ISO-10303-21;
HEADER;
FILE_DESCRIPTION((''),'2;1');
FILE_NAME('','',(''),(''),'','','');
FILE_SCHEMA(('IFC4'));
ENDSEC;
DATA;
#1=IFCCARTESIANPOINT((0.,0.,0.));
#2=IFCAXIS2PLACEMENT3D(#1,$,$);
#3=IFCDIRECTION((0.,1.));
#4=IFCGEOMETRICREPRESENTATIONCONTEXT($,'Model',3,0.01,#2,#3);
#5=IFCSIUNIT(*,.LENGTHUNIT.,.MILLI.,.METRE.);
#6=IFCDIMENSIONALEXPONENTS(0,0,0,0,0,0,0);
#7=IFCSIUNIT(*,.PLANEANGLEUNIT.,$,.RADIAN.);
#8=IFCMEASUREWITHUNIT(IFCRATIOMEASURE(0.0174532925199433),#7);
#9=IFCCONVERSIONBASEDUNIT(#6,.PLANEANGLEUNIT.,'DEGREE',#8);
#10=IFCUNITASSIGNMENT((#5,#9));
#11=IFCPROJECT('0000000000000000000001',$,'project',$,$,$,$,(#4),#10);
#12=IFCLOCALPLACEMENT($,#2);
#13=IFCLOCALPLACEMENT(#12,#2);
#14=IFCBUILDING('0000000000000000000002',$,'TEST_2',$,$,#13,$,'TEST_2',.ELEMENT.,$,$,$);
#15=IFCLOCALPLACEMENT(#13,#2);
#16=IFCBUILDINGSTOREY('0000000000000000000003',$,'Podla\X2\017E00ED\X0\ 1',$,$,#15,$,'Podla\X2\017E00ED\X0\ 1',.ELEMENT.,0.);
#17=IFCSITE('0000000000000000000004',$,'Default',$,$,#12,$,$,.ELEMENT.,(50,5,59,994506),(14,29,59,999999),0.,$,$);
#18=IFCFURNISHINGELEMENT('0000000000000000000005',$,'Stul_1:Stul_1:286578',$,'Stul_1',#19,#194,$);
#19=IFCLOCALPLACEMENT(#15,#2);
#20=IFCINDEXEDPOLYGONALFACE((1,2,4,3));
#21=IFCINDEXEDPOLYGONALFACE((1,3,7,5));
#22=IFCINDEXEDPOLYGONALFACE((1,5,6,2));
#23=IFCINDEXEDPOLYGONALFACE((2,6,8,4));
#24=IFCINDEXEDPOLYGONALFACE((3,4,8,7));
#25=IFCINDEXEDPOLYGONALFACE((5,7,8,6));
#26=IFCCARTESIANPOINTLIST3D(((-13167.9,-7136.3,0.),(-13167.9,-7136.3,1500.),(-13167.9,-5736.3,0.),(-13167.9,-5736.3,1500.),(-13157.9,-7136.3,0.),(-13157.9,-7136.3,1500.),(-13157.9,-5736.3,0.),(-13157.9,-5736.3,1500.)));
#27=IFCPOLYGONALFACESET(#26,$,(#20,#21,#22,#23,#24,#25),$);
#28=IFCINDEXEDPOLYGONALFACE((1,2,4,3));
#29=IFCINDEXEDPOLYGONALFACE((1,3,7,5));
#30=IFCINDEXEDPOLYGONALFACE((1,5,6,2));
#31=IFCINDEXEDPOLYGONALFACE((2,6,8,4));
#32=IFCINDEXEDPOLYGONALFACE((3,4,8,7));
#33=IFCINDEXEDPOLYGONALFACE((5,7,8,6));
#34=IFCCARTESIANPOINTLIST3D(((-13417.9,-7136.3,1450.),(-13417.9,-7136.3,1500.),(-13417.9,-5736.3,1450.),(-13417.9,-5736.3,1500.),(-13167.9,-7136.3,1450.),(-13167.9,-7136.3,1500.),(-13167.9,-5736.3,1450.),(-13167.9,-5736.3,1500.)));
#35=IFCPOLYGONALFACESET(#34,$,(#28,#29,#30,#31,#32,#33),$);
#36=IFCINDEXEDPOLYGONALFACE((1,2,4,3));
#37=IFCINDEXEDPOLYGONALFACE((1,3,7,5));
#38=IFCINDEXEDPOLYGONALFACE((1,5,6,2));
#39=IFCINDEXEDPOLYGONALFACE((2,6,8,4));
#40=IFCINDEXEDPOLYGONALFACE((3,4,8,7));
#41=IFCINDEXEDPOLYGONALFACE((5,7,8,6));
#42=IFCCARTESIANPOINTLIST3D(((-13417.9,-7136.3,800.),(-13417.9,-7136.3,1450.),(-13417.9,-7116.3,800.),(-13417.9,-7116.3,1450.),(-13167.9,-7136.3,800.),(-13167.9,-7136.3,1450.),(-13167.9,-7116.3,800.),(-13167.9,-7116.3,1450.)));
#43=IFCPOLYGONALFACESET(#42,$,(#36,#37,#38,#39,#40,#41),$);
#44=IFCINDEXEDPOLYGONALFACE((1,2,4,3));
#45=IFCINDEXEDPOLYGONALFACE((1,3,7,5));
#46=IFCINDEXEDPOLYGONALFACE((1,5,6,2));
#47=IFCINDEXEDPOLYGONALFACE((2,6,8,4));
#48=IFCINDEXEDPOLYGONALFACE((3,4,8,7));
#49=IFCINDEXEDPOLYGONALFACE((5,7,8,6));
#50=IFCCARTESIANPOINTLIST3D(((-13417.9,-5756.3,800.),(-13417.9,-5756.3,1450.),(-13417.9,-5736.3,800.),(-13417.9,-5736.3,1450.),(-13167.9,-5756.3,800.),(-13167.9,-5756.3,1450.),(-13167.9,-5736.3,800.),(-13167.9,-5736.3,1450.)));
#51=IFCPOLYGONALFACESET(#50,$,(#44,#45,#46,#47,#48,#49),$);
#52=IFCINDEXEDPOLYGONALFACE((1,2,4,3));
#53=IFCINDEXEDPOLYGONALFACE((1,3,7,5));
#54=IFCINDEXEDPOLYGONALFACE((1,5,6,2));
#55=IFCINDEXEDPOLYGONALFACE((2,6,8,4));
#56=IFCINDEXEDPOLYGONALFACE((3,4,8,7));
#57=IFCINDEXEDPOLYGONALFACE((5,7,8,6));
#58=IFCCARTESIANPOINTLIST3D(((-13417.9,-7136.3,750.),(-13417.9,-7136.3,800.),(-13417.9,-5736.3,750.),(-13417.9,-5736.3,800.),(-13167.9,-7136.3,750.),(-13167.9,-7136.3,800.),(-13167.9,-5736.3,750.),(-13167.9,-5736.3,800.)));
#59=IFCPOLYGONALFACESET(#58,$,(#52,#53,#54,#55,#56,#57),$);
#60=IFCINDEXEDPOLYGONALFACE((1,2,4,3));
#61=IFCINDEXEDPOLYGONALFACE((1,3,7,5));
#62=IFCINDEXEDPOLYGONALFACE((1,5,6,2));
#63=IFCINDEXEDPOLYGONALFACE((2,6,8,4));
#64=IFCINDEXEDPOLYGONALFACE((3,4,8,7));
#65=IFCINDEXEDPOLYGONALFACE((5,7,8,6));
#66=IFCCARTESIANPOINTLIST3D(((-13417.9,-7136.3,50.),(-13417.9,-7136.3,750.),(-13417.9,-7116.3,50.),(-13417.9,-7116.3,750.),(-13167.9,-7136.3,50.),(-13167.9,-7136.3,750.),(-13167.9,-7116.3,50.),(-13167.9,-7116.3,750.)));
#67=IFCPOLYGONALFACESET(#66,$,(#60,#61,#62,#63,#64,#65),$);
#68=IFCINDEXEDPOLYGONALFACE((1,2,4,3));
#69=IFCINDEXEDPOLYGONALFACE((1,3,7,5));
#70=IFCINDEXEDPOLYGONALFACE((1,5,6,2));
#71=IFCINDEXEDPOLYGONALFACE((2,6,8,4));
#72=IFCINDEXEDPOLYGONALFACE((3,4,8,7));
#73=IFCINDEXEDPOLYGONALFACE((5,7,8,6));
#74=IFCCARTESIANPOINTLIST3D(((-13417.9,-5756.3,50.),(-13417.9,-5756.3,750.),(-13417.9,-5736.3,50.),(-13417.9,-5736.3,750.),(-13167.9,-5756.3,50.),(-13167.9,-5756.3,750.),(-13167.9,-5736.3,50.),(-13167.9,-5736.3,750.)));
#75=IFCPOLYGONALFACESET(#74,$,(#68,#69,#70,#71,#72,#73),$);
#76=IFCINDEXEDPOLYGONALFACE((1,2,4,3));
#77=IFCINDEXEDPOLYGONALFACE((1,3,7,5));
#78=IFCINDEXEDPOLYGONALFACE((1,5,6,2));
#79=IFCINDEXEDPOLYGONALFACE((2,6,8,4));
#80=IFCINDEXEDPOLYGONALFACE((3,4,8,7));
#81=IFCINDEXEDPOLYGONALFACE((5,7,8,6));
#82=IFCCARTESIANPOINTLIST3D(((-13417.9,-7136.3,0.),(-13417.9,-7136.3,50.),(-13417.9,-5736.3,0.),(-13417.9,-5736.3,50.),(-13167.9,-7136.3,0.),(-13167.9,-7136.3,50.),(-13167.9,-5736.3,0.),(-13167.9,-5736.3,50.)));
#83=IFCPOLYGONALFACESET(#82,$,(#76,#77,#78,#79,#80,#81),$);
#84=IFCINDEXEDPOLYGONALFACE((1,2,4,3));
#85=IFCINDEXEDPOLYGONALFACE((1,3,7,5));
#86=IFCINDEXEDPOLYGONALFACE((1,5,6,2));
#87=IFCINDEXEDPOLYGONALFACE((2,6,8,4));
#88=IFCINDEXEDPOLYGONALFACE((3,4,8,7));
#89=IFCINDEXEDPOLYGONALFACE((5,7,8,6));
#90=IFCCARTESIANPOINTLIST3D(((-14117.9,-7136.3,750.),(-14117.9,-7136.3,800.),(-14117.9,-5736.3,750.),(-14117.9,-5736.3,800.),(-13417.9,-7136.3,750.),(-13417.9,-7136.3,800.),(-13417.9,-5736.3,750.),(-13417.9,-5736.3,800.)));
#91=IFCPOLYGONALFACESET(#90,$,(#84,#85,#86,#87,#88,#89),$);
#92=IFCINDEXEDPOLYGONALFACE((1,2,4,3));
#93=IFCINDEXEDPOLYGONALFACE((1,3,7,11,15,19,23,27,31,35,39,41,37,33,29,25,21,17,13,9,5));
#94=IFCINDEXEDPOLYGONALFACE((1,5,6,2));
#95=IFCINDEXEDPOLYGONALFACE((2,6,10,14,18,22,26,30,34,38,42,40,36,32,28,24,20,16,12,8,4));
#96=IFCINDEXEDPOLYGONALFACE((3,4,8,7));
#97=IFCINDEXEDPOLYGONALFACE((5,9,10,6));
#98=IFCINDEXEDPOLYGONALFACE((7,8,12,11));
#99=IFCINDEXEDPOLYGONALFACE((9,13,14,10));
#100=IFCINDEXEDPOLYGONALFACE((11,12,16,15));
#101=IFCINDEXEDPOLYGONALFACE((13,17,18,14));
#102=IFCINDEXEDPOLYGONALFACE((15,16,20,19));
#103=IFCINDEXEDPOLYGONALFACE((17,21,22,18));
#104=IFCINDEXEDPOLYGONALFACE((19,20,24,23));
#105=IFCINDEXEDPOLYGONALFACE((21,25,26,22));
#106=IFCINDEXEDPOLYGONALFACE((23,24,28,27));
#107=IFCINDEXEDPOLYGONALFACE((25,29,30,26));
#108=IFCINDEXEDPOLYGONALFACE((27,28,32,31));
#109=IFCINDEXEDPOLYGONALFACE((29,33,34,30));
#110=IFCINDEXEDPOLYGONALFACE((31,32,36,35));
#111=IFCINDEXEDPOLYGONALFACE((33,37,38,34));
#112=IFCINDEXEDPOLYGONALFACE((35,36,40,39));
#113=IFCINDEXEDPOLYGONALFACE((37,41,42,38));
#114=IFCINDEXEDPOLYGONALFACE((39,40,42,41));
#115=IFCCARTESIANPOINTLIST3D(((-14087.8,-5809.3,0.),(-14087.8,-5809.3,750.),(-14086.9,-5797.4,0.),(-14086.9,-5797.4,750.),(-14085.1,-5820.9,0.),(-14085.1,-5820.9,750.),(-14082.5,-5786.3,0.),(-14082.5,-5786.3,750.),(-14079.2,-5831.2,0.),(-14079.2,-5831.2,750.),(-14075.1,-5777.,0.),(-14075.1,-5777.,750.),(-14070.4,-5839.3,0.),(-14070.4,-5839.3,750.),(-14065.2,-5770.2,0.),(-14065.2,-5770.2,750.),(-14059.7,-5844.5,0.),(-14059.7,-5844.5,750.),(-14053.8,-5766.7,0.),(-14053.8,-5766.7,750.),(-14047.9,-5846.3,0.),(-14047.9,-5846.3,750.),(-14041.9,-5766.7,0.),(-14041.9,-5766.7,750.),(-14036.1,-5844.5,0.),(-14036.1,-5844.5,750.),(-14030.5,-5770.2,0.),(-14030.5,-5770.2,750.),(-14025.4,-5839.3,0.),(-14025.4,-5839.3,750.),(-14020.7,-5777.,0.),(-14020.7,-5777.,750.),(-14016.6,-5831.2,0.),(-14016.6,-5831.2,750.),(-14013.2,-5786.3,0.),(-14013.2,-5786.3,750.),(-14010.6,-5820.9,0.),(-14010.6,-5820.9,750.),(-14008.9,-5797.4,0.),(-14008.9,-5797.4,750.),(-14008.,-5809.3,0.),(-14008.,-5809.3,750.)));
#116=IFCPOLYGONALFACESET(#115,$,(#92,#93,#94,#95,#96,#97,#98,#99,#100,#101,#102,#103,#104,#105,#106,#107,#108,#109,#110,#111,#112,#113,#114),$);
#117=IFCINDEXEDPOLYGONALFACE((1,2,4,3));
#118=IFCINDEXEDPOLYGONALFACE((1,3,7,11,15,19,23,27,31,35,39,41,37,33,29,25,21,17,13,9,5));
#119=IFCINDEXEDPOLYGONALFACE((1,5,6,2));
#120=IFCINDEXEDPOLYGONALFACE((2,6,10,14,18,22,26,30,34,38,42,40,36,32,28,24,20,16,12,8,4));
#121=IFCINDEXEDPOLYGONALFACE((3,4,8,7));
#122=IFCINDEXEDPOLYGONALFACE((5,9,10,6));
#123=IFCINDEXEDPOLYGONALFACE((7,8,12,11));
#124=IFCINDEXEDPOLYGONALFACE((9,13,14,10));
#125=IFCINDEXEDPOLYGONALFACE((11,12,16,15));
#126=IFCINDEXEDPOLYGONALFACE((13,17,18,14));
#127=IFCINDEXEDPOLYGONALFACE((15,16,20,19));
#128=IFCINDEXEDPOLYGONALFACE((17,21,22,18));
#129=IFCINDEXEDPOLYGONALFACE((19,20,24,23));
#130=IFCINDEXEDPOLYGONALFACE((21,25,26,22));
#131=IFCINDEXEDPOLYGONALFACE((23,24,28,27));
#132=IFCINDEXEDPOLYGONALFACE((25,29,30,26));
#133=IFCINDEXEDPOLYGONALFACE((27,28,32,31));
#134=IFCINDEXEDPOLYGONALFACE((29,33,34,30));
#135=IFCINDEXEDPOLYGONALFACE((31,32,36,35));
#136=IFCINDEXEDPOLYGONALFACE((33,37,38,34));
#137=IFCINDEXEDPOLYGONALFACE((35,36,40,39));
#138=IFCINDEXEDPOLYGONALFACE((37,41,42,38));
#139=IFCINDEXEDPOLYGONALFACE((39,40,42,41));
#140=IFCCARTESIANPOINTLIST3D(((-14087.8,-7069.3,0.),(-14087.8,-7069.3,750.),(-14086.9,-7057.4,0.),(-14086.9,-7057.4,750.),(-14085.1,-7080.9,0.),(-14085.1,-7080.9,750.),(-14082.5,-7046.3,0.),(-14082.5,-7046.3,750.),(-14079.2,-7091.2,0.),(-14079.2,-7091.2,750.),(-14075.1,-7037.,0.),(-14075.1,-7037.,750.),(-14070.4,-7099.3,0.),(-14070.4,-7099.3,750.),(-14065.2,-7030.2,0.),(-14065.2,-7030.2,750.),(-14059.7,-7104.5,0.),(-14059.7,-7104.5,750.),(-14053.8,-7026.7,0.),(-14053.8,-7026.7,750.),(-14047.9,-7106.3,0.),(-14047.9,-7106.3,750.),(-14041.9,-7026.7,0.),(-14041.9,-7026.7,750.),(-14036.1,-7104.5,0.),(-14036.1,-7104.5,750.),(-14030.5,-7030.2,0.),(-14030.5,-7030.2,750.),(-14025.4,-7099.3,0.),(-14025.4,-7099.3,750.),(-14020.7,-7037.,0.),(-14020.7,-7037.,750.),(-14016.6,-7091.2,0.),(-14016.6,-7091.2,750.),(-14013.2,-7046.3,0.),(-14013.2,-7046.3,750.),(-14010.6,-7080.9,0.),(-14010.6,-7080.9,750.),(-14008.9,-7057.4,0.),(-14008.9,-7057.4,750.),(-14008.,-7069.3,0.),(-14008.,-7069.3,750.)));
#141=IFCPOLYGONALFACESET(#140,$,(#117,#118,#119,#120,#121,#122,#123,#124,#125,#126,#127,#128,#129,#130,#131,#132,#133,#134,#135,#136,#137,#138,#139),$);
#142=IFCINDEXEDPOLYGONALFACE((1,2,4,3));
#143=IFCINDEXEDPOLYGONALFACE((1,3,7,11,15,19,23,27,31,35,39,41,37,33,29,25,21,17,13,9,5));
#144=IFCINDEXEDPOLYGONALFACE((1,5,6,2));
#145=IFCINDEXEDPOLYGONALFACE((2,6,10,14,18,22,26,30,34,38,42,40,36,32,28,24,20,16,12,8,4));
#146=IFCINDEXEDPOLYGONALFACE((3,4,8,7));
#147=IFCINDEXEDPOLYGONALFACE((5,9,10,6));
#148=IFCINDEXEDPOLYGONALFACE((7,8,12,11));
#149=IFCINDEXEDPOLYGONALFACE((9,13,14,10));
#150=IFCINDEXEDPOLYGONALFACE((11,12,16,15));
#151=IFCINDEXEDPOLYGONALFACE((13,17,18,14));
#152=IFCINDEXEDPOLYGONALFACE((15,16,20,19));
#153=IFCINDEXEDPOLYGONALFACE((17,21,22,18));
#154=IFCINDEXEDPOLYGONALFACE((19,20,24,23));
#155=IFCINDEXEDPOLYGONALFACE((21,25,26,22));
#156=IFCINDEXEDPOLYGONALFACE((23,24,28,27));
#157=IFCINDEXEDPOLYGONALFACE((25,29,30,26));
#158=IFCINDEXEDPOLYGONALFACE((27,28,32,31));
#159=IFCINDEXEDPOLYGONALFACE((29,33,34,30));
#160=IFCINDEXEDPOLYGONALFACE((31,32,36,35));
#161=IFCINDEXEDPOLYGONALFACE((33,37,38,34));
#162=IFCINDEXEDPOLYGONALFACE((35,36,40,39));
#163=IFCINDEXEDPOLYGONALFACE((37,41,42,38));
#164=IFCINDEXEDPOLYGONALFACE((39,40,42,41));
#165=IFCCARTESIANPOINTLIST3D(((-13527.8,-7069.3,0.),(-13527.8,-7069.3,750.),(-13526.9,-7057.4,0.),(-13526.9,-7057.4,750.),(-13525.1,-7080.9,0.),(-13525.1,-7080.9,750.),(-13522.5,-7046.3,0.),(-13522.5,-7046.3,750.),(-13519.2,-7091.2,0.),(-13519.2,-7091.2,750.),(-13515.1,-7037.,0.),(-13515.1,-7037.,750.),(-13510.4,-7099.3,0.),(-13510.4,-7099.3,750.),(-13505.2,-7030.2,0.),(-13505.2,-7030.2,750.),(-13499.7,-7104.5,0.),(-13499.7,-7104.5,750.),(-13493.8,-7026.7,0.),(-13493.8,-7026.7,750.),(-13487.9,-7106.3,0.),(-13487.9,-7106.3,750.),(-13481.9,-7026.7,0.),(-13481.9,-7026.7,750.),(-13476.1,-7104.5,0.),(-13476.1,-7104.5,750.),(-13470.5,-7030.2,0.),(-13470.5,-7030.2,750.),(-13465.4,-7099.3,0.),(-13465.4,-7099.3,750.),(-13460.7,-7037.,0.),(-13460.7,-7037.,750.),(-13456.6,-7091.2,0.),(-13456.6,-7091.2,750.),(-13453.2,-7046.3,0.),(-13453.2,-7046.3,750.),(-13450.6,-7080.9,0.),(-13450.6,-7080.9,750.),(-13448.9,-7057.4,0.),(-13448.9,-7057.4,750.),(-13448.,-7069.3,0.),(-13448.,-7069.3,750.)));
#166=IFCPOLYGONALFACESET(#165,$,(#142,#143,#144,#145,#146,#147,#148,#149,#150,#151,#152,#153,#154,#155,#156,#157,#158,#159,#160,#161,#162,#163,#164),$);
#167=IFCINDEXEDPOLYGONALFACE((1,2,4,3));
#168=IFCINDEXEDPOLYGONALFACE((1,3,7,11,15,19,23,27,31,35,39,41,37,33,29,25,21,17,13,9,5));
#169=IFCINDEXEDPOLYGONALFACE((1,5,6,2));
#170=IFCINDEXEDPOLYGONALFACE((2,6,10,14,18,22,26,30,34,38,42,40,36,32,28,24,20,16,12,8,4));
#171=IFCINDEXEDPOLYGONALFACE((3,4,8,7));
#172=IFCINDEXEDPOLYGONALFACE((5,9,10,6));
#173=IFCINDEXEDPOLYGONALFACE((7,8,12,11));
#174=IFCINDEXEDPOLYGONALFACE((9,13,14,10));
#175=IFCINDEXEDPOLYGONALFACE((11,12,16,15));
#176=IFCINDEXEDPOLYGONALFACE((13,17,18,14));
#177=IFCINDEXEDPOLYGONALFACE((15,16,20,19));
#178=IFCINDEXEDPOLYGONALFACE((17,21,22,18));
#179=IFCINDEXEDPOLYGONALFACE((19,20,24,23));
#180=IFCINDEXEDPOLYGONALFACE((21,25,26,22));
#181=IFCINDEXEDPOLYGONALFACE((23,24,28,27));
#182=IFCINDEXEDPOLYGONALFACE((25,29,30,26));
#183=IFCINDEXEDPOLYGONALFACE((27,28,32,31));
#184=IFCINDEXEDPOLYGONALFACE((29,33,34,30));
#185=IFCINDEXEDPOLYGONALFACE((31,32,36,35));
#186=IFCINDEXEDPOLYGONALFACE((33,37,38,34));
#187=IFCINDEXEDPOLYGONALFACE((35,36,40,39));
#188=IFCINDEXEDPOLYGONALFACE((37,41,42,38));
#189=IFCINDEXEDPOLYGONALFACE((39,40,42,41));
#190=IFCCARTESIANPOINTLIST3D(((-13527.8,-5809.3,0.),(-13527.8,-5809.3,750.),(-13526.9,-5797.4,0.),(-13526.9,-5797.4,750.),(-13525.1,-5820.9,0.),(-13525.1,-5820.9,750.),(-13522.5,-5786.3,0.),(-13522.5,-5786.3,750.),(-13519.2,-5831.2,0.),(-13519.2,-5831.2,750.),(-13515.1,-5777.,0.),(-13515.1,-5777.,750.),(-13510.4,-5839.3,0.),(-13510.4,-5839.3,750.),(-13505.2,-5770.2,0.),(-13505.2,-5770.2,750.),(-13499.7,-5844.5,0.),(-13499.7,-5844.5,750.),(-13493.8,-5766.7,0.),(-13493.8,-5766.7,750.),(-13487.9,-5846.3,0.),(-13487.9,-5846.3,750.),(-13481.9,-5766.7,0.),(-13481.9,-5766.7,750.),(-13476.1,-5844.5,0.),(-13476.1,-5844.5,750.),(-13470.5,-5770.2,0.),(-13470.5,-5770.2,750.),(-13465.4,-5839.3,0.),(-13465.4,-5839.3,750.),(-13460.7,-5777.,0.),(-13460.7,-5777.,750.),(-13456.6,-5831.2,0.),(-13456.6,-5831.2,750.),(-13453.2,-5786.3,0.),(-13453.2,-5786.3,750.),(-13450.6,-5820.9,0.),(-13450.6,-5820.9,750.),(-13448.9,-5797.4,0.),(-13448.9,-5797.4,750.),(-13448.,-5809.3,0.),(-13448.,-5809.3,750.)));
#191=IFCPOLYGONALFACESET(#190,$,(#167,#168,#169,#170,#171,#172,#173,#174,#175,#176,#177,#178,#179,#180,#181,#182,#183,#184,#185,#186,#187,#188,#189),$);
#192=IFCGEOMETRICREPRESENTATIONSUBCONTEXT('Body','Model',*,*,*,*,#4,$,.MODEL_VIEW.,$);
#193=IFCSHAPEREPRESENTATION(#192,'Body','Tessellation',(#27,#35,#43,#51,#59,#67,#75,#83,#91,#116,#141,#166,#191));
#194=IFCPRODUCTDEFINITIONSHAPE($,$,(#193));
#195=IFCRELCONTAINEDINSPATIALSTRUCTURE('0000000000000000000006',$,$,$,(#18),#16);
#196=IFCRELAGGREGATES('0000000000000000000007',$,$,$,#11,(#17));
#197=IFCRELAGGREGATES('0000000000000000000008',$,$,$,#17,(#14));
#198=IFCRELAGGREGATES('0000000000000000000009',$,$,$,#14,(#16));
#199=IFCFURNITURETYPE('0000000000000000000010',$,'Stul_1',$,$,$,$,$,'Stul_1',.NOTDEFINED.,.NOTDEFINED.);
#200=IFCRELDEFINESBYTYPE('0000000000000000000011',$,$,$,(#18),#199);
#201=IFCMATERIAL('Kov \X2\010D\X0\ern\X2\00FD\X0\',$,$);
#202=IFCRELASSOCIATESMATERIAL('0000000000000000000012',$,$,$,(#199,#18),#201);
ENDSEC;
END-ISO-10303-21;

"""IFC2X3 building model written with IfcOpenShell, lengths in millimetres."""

from ifc_helpers import new_model, entity, si_unit, converted_unit, direction, frame, frame_2d, origin, origin_2d_with_axis, place, context, subcontext, project, spatial, rectangle, circle, extrude, source, transform, mapped, material, type_object, type_shapes, element, save


model = new_model("IFC2X3")

# Units and contexts
model_context = context("Model", 3, precision=0.01, world=origin(), true_north=direction((0.0, 1.0)))
body_context = subcontext(model_context, "Body", "Model", "MODEL_VIEW")
ifc_project = project(units=[si_unit("LENGTHUNIT", "METRE", prefix="MILLI"), converted_unit("PLANEANGLEUNIT", "DEGREE", entity("IfcRatioMeasure", 0.0174532925199433), si_unit("PLANEANGLEUNIT", "RADIAN"), dimensions=[0, 0, 0, 0, 0, 0, 0])], contexts=[model_context])

# Site, building, storey
site_placement = place(None, origin())
site = spatial("IfcSite", under=ifc_project, at=site_placement, Name="Default", CompositionType="ELEMENT", RefLatitude=(50, 5, 59, 994506), RefLongitude=(14, 29, 59, 999999), RefElevation=0.0)
building_placement = place(site_placement, origin())
building = spatial("IfcBuilding", under=site, at=building_placement, Name="TEST_2", LongName="TEST_2", CompositionType="ELEMENT")
storey_placement = place(building_placement, origin())
storey = spatial("IfcBuildingStorey", under=building, at=storey_placement, Name="Podlaží 1", LongName="Podlaží 1", CompositionType="ELEMENT", Elevation=0.0)

# Furnishing element
ifc_material_1 = material(Name="Kov černý")
furniture_type = type_object("IfcFurnitureType", Name="Stul_1", ElementType="Stul_1", material=ifc_material_1)
shared_shape_1 = source(origin(), body_context, "Body", "SweptSolid", [
    extrude(rectangle(XDim=1400.0, YDim=10.0, at=origin_2d_with_axis()), frame((0.0, 605.0, 0.0), z_axis=(0.0, 0.0, 1.0), x_axis=(-1.0, 0.0, 0.0)), (0.0, 0.0, 1.0), 1500.0),
    extrude(rectangle(XDim=1400.0, YDim=250.0, at=frame_2d((0.0, 0.0), x_axis=(1.0, 0.0))), frame((0.0, 475.0, 1450.0), z_axis=(0.0, 0.0, 1.0), x_axis=(-1.0, 0.0, 0.0)), (0.0, 0.0, 1.0), 50.0),
    extrude(rectangle(XDim=20.0, YDim=250.0, at=origin_2d_with_axis()), frame((690.0, 475.0, 800.0), z_axis=(0.0, 0.0, 1.0), x_axis=(-1.0, 0.0, 0.0)), (0.0, 0.0, 1.0), 650.0),
    extrude(rectangle(XDim=20.0, YDim=250.0, at=frame_2d((0.0, 0.0), x_axis=(1.0, 0.0))), frame((-690.0, 475.0, 800.0), z_axis=(0.0, 0.0, 1.0), x_axis=(-1.0, 0.0, 0.0)), (0.0, 0.0, 1.0), 650.0),
    extrude(rectangle(XDim=1400.0, YDim=250.0, at=origin_2d_with_axis()), frame((0.0, 475.0, 750.0), z_axis=(0.0, 0.0, 1.0), x_axis=(-1.0, 0.0, 0.0)), (0.0, 0.0, 1.0), 50.0),
    extrude(rectangle(XDim=20.0, YDim=250.0, at=origin_2d_with_axis()), frame((690.0, 475.0, 50.0), z_axis=(0.0, 0.0, 1.0), x_axis=(-1.0, 0.0, 0.0)), (0.0, 0.0, 1.0), 700.0),
    extrude(rectangle(XDim=20.0, YDim=250.0, at=frame_2d((0.0, 0.0), x_axis=(1.0, 0.0))), frame((-690.0, 475.0, 50.0), z_axis=(0.0, 0.0, 1.0), x_axis=(-1.0, 0.0, 0.0)), (0.0, 0.0, 1.0), 700.0),
    extrude(rectangle(XDim=1400.0, YDim=250.0, at=origin_2d_with_axis()), frame((0.0, 475.0, 0.0), z_axis=(0.0, 0.0, 1.0), x_axis=(-1.0, 0.0, 0.0)), (0.0, 0.0, 1.0), 50.0),
    extrude(rectangle(XDim=1400.0, YDim=700.0, at=origin_2d_with_axis()), frame((0.0, 0.0, 750.0), z_axis=(0.0, 0.0, 1.0), x_axis=(-1.0, 0.0, 0.0)), (0.0, 0.0, 1.0), 50.0),
    extrude(circle(Radius=40.0, at=frame_2d((0.0, 0.0), x_axis=(1.0, 0.0))), frame((-630.0, -280.0, 0.0)), (0.0, 0.0, 1.0), 750.0),
    extrude(circle(Radius=40.0, at=frame_2d((0.0, 0.0), x_axis=(1.0, 0.0))), frame((630.0, -280.0, 0.0)), (0.0, 0.0, 1.0), 750.0),
    extrude(circle(Radius=40.0, at=frame_2d((0.0, 0.0), x_axis=(1.0, 0.0))), frame((630.0, 280.0, 0.0)), (0.0, 0.0, 1.0), 750.0),
    extrude(circle(Radius=40.0, at=frame_2d((0.0, 0.0), x_axis=(1.0, 0.0))), frame((-630.0, 280.0, 0.0)), (0.0, 0.0, 1.0), 750.0),
])
type_shapes(furniture_type, [shared_shape_1])
for number, where, z_axis, x_axis, name in (
    (1, (-13767.9, -6436.3, 0.0), (0.0, 0.0, 1.0), (0.0, -1.0, 0.0), "Stul_1:Stul_1:286578"),
):
    element("IfcFurnishingElement", number, at=place(storey_placement, frame(where, z_axis=z_axis, x_axis=x_axis)), inside=storey, type_object=furniture_type, material=ifc_material_1, Name=name, ObjectType="Stul_1", context=body_context, shape_type="MappedRepresentation", body=[
        mapped(shared_shape_1, transform((0.0, 0.0, 0.0), scale=1.0)),
    ])

save(model, "model.ifc")
